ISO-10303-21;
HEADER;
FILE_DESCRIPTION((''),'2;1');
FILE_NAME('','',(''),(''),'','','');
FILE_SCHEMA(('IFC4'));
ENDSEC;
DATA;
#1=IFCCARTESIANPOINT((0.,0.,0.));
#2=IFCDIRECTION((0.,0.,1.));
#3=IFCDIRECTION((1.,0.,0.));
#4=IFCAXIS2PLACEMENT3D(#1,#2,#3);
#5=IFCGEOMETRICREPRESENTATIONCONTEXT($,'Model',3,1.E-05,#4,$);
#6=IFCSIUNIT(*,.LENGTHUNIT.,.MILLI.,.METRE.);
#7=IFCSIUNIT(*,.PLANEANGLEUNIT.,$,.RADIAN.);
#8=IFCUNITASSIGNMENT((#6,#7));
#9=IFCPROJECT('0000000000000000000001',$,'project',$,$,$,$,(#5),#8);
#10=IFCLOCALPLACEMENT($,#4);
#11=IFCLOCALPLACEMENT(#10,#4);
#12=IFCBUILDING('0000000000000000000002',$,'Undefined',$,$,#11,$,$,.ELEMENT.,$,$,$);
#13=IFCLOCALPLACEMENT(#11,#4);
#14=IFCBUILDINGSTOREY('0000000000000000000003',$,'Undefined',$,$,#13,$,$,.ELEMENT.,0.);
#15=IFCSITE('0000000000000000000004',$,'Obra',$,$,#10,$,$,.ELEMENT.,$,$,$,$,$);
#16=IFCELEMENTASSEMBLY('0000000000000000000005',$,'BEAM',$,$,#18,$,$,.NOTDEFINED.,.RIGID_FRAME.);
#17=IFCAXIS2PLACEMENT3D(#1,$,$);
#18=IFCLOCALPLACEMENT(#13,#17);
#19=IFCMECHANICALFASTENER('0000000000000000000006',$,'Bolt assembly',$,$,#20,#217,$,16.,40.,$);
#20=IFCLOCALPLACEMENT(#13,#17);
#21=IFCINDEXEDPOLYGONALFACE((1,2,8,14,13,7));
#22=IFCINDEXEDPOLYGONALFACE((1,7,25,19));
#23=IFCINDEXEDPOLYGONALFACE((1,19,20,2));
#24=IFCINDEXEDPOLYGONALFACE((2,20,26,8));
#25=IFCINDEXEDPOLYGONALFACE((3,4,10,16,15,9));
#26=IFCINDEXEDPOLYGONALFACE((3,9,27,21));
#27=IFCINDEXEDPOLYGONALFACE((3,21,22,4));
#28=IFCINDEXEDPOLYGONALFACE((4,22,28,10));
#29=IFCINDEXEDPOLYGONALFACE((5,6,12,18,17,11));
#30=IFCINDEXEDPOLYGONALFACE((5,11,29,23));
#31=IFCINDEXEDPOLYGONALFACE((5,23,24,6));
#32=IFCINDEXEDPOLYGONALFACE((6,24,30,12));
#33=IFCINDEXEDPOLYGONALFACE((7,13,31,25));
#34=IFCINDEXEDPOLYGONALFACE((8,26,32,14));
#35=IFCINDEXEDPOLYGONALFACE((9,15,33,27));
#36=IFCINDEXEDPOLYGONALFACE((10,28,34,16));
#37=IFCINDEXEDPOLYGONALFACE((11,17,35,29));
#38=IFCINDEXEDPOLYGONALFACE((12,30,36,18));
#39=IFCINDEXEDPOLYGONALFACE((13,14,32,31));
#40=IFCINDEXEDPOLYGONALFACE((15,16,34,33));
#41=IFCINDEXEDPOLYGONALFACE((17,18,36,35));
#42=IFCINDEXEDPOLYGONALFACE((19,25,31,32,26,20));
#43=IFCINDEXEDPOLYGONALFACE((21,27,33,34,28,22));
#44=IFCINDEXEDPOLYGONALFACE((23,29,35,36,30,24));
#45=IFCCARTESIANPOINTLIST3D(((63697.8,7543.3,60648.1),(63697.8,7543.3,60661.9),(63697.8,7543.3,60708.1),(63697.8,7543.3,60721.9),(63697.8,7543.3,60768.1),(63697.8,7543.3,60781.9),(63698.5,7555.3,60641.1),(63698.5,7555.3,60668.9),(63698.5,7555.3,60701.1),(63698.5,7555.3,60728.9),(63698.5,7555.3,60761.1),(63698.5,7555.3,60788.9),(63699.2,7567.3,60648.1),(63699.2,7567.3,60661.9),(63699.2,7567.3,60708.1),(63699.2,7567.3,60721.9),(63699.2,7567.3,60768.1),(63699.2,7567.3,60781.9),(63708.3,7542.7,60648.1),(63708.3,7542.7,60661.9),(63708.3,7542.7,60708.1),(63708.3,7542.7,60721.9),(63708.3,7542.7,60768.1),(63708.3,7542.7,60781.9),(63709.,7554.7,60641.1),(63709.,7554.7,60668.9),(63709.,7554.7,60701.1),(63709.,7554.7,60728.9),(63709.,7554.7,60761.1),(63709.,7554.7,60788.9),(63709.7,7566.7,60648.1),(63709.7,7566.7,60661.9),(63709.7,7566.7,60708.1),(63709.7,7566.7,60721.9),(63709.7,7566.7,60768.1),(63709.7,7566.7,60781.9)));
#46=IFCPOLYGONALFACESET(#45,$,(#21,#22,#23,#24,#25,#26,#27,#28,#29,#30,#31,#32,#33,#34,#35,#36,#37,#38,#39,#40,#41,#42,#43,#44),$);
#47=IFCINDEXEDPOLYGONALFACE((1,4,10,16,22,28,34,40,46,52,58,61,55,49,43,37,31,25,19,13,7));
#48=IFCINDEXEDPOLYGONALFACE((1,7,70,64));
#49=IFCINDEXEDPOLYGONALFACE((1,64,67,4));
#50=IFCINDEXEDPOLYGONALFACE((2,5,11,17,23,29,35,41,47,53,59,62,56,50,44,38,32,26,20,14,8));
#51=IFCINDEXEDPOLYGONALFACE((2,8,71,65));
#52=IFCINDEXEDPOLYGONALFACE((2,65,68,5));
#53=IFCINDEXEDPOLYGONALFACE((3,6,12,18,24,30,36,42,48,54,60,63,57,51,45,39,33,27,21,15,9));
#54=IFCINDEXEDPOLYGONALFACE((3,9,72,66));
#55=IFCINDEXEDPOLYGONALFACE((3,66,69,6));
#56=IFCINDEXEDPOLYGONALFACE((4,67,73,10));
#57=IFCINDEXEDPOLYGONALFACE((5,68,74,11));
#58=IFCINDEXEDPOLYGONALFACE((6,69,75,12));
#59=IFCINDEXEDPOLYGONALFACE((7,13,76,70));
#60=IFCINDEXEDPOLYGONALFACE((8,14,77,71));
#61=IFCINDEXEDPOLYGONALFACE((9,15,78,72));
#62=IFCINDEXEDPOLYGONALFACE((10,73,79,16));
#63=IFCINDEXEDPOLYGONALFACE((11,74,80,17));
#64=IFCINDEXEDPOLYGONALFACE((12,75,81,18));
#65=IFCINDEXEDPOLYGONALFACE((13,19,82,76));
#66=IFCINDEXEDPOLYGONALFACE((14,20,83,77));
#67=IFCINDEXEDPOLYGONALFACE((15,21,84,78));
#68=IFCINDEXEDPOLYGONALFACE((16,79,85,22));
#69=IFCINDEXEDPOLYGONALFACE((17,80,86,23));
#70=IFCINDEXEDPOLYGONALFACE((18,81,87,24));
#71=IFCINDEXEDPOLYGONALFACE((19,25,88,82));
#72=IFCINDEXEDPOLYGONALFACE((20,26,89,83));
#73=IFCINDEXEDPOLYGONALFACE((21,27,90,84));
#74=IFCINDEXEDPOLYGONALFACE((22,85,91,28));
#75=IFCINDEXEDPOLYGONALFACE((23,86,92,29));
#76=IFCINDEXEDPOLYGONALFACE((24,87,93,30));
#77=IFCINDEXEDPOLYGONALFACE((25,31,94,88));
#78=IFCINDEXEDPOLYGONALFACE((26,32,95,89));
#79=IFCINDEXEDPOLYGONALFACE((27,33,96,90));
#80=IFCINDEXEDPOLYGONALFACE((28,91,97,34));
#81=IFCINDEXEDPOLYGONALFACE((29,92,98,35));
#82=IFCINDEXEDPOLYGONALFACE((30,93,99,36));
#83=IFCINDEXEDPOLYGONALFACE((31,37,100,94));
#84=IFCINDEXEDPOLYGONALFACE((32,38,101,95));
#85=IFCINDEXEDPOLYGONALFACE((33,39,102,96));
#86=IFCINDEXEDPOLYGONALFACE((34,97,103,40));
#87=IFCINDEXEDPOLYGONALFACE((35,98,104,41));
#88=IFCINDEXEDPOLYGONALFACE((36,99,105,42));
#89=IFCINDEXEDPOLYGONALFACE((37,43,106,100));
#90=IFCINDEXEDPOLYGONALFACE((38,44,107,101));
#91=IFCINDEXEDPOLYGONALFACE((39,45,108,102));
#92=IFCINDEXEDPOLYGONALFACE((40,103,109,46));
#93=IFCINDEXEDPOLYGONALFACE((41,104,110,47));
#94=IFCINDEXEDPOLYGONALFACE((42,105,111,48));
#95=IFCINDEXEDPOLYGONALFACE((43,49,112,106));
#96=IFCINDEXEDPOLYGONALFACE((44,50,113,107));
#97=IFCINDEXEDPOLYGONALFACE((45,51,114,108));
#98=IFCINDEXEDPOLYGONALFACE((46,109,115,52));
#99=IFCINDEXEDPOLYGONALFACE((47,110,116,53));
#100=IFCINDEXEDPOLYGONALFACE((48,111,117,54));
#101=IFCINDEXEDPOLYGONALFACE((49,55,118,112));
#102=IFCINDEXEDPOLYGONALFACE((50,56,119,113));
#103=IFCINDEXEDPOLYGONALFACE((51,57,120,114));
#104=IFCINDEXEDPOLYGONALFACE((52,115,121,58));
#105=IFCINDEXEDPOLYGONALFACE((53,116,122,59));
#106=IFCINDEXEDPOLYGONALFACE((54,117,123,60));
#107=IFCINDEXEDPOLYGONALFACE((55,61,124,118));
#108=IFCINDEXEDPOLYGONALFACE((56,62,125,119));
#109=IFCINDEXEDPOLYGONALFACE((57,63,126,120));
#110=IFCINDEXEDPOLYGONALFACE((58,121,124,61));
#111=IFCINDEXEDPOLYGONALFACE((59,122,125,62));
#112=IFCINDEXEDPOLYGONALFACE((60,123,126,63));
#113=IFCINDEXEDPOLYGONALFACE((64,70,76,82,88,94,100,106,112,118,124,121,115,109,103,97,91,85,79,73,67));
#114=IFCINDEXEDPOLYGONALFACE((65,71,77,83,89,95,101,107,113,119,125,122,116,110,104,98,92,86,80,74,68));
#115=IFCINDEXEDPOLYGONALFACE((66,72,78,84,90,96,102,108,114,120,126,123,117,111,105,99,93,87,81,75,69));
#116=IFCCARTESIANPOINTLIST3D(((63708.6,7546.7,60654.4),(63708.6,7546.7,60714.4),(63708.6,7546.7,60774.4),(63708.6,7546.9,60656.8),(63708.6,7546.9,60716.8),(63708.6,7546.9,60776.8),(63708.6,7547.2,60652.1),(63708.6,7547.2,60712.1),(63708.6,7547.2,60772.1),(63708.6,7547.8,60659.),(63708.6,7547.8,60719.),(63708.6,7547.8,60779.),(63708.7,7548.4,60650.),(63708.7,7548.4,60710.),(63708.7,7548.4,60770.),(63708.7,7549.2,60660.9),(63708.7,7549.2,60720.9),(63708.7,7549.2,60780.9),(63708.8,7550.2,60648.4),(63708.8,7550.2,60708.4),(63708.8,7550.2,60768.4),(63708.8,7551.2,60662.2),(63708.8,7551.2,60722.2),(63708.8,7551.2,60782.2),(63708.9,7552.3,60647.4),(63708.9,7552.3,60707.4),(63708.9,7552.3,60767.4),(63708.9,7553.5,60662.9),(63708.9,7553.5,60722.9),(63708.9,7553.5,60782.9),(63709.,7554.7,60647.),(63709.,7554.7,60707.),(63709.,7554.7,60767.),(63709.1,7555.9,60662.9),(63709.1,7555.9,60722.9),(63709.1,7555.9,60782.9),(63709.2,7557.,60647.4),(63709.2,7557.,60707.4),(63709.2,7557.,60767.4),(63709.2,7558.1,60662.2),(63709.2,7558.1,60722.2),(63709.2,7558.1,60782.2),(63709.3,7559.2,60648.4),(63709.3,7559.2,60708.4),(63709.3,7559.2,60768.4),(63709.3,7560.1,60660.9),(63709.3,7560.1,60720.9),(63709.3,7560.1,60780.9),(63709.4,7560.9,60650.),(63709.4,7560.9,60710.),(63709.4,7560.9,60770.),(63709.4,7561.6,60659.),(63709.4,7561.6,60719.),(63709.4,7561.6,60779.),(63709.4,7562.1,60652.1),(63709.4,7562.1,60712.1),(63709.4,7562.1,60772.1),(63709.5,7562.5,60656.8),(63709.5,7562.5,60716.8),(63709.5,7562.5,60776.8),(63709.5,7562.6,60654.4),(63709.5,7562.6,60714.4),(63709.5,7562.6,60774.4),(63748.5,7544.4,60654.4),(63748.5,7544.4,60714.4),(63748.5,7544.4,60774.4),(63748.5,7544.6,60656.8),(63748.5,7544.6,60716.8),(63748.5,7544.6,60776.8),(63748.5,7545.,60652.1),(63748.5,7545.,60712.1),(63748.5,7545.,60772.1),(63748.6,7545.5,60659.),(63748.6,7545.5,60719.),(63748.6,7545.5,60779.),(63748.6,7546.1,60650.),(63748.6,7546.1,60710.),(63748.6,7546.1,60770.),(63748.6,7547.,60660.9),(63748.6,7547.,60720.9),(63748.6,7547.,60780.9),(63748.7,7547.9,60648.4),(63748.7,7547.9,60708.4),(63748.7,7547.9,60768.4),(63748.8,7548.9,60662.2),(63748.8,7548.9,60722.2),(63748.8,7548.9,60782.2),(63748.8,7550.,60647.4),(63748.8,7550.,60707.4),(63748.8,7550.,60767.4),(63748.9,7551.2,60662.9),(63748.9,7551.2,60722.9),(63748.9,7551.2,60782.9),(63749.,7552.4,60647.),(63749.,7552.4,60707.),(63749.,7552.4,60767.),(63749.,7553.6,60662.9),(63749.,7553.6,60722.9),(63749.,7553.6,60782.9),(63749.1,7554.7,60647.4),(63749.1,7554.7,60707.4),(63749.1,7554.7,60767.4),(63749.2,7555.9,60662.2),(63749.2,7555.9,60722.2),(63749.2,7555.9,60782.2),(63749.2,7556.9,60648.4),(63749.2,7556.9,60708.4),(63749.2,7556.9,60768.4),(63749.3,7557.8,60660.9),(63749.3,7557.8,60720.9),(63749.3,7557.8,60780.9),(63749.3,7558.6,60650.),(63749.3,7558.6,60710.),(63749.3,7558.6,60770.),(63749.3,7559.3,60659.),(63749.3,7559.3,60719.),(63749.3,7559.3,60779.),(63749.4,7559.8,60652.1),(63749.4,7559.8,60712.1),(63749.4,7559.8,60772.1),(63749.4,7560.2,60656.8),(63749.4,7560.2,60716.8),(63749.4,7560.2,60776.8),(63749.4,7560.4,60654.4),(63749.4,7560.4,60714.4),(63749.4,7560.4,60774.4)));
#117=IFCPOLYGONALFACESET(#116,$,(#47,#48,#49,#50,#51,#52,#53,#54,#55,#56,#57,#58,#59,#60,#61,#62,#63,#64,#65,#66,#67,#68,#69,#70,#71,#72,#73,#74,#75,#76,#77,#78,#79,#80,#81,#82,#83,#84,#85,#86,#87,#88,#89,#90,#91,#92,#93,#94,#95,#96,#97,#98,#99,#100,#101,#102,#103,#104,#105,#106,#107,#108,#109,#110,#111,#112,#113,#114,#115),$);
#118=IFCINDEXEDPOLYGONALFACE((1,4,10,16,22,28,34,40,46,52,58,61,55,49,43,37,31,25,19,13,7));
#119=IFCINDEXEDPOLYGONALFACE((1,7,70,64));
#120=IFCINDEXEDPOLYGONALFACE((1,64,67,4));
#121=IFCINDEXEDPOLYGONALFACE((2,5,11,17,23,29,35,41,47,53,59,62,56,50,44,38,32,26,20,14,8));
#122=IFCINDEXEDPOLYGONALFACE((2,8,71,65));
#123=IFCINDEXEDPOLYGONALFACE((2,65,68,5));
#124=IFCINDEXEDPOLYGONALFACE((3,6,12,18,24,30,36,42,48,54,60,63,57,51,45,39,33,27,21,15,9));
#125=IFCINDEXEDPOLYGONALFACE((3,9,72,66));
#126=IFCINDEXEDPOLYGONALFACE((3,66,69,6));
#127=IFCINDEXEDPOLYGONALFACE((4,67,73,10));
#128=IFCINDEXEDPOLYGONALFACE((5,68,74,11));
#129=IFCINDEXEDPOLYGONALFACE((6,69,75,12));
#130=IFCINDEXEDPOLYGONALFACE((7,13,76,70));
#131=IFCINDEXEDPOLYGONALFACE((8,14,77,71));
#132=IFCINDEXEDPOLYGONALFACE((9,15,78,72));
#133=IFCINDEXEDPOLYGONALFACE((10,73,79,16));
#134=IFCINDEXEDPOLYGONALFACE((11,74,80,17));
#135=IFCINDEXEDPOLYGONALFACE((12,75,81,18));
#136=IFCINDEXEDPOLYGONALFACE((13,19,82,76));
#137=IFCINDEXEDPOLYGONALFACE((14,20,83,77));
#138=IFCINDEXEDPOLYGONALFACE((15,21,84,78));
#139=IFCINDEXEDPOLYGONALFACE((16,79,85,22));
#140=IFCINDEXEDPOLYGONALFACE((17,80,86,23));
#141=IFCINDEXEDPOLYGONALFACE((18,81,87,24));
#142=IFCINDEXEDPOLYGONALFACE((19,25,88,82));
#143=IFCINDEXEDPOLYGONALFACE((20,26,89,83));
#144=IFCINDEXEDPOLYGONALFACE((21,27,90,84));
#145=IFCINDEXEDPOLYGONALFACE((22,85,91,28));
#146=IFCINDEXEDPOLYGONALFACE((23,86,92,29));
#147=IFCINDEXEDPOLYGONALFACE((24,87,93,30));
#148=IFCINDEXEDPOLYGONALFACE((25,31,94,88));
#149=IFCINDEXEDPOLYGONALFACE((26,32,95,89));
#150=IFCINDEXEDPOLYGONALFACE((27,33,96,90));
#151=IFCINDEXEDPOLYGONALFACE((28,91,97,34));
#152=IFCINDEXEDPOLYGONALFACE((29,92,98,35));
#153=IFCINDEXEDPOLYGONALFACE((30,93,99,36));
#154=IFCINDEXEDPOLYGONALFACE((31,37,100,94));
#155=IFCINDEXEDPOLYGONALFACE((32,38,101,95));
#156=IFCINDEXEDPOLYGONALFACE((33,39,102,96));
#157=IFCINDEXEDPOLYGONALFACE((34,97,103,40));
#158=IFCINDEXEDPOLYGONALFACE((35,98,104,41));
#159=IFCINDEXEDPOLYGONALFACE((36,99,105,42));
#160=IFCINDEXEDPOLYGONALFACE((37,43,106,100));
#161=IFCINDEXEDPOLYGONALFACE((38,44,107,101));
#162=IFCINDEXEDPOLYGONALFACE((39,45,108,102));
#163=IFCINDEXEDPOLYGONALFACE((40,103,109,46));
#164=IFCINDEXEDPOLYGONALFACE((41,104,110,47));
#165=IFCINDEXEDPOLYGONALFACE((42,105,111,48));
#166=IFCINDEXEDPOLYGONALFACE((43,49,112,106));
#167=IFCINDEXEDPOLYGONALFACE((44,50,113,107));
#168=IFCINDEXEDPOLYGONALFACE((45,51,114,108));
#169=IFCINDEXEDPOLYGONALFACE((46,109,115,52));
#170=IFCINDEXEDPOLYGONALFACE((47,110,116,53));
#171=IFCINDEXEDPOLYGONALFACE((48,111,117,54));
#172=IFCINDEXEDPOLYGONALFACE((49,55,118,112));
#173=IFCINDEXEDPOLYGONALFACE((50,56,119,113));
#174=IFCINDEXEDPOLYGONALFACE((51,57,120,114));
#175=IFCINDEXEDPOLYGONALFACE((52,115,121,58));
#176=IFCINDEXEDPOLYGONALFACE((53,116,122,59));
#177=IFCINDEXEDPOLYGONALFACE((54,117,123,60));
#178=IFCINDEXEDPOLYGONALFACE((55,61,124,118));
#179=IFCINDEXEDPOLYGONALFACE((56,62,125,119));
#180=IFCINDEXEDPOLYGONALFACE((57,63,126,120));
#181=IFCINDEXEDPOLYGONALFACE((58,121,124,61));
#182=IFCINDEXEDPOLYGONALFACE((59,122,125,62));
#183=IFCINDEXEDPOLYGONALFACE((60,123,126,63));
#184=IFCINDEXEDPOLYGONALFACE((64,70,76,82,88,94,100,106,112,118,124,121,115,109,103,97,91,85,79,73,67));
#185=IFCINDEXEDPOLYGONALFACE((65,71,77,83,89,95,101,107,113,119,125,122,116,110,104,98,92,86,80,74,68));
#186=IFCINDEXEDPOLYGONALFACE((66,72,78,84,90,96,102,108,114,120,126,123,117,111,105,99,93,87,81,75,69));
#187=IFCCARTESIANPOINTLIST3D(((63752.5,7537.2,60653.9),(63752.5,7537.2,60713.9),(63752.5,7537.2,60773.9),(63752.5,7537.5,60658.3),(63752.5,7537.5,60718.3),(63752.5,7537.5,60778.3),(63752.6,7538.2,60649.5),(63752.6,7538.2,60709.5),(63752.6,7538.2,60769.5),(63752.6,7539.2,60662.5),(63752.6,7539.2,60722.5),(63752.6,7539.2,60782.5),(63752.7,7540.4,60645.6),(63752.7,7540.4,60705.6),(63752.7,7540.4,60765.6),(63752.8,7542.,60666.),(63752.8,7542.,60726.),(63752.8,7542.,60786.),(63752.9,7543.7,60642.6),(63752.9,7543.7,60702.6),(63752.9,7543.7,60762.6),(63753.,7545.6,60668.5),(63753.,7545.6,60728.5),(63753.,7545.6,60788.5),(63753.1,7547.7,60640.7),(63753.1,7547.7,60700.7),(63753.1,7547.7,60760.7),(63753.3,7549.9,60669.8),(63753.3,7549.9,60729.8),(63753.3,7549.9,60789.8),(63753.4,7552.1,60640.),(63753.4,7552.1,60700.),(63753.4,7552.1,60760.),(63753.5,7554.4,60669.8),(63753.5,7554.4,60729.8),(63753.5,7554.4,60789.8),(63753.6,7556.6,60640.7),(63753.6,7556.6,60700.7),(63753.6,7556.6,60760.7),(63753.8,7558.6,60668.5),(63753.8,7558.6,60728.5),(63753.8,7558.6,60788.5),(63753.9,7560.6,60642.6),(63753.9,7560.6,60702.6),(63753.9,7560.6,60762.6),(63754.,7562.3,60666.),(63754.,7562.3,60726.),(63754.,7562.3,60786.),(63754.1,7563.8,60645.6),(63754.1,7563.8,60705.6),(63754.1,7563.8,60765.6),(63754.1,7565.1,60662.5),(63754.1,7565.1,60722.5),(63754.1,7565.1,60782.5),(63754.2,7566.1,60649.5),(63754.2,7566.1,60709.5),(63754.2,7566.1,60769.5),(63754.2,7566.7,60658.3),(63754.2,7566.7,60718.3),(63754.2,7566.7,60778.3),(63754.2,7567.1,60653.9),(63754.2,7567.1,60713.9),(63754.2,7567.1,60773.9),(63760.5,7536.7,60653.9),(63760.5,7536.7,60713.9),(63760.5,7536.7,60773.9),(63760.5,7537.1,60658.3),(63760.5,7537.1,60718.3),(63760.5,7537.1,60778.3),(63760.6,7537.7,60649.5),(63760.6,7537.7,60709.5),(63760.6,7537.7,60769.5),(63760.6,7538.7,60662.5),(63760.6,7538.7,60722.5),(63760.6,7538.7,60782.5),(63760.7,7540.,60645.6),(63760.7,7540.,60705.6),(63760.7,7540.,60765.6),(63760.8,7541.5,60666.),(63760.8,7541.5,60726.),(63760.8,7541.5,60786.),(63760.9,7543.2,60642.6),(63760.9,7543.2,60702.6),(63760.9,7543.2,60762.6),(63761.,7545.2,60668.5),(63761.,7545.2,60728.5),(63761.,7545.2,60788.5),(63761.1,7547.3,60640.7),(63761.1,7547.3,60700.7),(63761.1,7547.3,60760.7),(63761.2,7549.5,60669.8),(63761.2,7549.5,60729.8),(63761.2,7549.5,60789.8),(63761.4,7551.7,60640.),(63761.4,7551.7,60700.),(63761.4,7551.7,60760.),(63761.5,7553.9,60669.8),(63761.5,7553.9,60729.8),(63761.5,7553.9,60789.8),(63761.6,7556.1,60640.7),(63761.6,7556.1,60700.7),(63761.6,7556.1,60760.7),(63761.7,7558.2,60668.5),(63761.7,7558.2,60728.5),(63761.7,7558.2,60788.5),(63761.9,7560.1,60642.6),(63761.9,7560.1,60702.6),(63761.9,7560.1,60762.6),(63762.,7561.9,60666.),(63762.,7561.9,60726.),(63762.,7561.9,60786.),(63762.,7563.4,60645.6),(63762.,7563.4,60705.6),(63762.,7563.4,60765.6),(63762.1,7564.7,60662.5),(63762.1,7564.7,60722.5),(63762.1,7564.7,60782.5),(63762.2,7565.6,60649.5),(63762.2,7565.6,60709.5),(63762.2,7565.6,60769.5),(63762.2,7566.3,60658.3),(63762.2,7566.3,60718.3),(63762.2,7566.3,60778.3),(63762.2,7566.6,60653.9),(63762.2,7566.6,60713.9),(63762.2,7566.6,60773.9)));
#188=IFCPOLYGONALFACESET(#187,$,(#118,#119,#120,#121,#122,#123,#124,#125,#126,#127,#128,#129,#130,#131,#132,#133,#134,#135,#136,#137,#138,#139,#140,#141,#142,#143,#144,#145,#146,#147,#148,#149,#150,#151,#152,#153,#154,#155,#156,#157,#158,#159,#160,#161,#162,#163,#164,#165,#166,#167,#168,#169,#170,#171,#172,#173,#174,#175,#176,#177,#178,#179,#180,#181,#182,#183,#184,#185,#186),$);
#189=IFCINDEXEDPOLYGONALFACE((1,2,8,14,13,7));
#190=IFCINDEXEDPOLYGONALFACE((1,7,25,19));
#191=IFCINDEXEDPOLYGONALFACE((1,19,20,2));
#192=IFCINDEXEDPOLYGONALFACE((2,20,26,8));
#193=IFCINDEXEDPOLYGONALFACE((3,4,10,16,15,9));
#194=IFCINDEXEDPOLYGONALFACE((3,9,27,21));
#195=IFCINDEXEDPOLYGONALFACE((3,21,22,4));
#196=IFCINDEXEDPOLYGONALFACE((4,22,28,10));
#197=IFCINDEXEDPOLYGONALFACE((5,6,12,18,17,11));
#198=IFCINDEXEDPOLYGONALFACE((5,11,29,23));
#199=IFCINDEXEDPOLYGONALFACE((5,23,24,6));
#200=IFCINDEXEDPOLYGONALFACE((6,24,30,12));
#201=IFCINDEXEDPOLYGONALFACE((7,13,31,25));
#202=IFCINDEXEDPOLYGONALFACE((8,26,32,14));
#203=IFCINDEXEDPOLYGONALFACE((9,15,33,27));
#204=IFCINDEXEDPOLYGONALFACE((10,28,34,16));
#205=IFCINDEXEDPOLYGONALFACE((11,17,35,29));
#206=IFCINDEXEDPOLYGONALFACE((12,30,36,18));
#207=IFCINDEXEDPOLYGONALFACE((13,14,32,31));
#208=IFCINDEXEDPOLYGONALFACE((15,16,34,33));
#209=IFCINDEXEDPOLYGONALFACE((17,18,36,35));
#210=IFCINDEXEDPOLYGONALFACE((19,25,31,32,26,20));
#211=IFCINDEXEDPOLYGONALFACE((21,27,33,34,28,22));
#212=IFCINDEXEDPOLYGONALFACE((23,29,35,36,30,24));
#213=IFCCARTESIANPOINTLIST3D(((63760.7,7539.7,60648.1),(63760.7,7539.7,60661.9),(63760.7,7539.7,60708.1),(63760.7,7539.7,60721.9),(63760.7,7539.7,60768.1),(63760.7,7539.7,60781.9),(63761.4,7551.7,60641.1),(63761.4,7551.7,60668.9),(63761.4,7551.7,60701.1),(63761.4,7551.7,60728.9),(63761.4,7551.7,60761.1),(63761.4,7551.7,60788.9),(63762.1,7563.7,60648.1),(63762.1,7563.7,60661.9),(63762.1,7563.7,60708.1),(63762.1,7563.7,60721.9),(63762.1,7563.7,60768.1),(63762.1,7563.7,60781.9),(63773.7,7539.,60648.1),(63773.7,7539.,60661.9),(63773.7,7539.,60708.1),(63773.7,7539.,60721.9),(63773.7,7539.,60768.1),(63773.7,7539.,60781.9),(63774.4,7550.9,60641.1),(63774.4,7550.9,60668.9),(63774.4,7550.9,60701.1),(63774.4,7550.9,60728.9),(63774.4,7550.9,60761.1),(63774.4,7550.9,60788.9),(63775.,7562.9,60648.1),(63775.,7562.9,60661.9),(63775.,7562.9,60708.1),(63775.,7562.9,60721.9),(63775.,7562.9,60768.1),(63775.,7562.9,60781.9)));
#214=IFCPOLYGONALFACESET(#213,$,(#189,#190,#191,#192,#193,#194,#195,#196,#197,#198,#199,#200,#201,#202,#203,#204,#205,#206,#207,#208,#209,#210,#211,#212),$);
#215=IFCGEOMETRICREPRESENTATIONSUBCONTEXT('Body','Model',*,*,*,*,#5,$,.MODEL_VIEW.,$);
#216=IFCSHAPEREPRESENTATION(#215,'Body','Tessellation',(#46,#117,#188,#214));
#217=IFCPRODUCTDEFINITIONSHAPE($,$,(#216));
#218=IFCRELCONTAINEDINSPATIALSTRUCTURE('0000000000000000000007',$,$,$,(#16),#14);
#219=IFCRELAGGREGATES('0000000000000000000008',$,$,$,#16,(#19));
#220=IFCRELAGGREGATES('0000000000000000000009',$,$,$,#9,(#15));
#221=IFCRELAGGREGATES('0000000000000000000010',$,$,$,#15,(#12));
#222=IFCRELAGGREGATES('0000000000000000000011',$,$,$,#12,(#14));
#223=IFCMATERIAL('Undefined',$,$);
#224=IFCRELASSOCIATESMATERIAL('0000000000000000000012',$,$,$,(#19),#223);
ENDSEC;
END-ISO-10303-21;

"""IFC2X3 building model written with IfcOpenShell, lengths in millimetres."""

from ifc_helpers import new_model, si_unit, frame, origin_with_axes, origin_2d_with_axis, place, context, subcontext, project, spatial, polyline, circle, outline, extrude, source, transform, mapped, material, element, aggregate, save


model = new_model("IFC2X3")

# Units and contexts
model_context = context("Model", 3, precision=1e-05, world=origin_with_axes())
body_context = subcontext(model_context, "Body", "Model", "MODEL_VIEW")
ifc_project = project(units=[si_unit("LENGTHUNIT", "METRE", prefix="MILLI"), si_unit("PLANEANGLEUNIT", "RADIAN")], contexts=[model_context])

# Site, building, storey
site_placement = place(None, origin_with_axes())
site = spatial("IfcSite", under=ifc_project, at=site_placement, Name="Obra", CompositionType="ELEMENT")
building_placement = place(site_placement, origin_with_axes())
building = spatial("IfcBuilding", under=site, at=building_placement, Name="Undefined", CompositionType="ELEMENT")
storey_placement = place(building_placement, origin_with_axes())
storey = spatial("IfcBuildingStorey", under=building, at=storey_placement, Name="Undefined", CompositionType="ELEMENT", Elevation=0.0)

# Element assembly, mechanical fastener
assembly_1_placement = place(storey_placement, origin_with_axes())
assembly_1 = element("IfcElementAssembly", 1, at=assembly_1_placement, inside=storey, Name="BEAM", AssemblyPlace="NOTDEFINED", PredefinedType="RIGID_FRAME")
ifc_material_1 = material(Name="Undefined")
shared_shape_1 = source(origin_with_axes(), body_context, "Body", "SweptSolid", [
    extrude(outline(polyline([(13.9, 0.0), (6.9, 12.0), (-6.9, 12.0), (-13.9, 0.0), (-6.9, -12.0), (6.9, -12.0), (13.9, 0.0)])), frame((0.0, -19.7, 0.0), z_axis=(0.0, 1.0, 0.0), x_axis=(1.0, 0.0, 0.0)), (0.0, 0.0, 1.0), 10.6),
    extrude(circle(Radius=8.0, at=origin_2d_with_axis()), frame((0.0, -9.1, 0.0), z_axis=(0.0, 1.0, 0.0), x_axis=(1.0, 0.0, 0.0)), (0.0, 0.0, 1.0), 40.0),
    extrude(circle(Radius=15.0, at=origin_2d_with_axis()), frame((0.0, 35.3, 0.0), z_axis=(0.0, 1.0, 0.0), x_axis=(1.0, 0.0, 0.0)), (0.0, 0.0, 1.0), 8.0),
    extrude(outline(polyline([(13.9, 0.0), (6.9, 12.0), (-6.9, 12.0), (-13.9, 0.0), (-6.9, -12.0), (6.9, -12.0), (13.9, 0.0)])), frame((0.0, 43.3, 0.0), z_axis=(0.0, 1.0, 0.0), x_axis=(1.0, 0.0, 0.0)), (0.0, 0.0, 1.0), 13.0),
])
mechanical_fastener_1_placement = place(assembly_1_placement, frame((63721.0, 7604.1, 60835.0), z_axis=(-0.05711, -0.998368, 0.0), x_axis=(0.0, 0.0, -1.0)))
mechanical_fastener_1 = element("IfcMechanicalFastener", 2, at=mechanical_fastener_1_placement, material=ifc_material_1, Name="Bolt assembly", NominalDiameter=16.0, NominalLength=40.0, context=body_context, shape_type="MappedRepresentation", body=[
    mapped(shared_shape_1, transform((60.0, 0.0, 50.0))),
    mapped(shared_shape_1, transform((120.0, 0.0, 50.0))),
    mapped(shared_shape_1, transform((180.0, 0.0, 50.0))),
])
aggregate(assembly_1, [mechanical_fastener_1])

save(model, "model.ifc")
